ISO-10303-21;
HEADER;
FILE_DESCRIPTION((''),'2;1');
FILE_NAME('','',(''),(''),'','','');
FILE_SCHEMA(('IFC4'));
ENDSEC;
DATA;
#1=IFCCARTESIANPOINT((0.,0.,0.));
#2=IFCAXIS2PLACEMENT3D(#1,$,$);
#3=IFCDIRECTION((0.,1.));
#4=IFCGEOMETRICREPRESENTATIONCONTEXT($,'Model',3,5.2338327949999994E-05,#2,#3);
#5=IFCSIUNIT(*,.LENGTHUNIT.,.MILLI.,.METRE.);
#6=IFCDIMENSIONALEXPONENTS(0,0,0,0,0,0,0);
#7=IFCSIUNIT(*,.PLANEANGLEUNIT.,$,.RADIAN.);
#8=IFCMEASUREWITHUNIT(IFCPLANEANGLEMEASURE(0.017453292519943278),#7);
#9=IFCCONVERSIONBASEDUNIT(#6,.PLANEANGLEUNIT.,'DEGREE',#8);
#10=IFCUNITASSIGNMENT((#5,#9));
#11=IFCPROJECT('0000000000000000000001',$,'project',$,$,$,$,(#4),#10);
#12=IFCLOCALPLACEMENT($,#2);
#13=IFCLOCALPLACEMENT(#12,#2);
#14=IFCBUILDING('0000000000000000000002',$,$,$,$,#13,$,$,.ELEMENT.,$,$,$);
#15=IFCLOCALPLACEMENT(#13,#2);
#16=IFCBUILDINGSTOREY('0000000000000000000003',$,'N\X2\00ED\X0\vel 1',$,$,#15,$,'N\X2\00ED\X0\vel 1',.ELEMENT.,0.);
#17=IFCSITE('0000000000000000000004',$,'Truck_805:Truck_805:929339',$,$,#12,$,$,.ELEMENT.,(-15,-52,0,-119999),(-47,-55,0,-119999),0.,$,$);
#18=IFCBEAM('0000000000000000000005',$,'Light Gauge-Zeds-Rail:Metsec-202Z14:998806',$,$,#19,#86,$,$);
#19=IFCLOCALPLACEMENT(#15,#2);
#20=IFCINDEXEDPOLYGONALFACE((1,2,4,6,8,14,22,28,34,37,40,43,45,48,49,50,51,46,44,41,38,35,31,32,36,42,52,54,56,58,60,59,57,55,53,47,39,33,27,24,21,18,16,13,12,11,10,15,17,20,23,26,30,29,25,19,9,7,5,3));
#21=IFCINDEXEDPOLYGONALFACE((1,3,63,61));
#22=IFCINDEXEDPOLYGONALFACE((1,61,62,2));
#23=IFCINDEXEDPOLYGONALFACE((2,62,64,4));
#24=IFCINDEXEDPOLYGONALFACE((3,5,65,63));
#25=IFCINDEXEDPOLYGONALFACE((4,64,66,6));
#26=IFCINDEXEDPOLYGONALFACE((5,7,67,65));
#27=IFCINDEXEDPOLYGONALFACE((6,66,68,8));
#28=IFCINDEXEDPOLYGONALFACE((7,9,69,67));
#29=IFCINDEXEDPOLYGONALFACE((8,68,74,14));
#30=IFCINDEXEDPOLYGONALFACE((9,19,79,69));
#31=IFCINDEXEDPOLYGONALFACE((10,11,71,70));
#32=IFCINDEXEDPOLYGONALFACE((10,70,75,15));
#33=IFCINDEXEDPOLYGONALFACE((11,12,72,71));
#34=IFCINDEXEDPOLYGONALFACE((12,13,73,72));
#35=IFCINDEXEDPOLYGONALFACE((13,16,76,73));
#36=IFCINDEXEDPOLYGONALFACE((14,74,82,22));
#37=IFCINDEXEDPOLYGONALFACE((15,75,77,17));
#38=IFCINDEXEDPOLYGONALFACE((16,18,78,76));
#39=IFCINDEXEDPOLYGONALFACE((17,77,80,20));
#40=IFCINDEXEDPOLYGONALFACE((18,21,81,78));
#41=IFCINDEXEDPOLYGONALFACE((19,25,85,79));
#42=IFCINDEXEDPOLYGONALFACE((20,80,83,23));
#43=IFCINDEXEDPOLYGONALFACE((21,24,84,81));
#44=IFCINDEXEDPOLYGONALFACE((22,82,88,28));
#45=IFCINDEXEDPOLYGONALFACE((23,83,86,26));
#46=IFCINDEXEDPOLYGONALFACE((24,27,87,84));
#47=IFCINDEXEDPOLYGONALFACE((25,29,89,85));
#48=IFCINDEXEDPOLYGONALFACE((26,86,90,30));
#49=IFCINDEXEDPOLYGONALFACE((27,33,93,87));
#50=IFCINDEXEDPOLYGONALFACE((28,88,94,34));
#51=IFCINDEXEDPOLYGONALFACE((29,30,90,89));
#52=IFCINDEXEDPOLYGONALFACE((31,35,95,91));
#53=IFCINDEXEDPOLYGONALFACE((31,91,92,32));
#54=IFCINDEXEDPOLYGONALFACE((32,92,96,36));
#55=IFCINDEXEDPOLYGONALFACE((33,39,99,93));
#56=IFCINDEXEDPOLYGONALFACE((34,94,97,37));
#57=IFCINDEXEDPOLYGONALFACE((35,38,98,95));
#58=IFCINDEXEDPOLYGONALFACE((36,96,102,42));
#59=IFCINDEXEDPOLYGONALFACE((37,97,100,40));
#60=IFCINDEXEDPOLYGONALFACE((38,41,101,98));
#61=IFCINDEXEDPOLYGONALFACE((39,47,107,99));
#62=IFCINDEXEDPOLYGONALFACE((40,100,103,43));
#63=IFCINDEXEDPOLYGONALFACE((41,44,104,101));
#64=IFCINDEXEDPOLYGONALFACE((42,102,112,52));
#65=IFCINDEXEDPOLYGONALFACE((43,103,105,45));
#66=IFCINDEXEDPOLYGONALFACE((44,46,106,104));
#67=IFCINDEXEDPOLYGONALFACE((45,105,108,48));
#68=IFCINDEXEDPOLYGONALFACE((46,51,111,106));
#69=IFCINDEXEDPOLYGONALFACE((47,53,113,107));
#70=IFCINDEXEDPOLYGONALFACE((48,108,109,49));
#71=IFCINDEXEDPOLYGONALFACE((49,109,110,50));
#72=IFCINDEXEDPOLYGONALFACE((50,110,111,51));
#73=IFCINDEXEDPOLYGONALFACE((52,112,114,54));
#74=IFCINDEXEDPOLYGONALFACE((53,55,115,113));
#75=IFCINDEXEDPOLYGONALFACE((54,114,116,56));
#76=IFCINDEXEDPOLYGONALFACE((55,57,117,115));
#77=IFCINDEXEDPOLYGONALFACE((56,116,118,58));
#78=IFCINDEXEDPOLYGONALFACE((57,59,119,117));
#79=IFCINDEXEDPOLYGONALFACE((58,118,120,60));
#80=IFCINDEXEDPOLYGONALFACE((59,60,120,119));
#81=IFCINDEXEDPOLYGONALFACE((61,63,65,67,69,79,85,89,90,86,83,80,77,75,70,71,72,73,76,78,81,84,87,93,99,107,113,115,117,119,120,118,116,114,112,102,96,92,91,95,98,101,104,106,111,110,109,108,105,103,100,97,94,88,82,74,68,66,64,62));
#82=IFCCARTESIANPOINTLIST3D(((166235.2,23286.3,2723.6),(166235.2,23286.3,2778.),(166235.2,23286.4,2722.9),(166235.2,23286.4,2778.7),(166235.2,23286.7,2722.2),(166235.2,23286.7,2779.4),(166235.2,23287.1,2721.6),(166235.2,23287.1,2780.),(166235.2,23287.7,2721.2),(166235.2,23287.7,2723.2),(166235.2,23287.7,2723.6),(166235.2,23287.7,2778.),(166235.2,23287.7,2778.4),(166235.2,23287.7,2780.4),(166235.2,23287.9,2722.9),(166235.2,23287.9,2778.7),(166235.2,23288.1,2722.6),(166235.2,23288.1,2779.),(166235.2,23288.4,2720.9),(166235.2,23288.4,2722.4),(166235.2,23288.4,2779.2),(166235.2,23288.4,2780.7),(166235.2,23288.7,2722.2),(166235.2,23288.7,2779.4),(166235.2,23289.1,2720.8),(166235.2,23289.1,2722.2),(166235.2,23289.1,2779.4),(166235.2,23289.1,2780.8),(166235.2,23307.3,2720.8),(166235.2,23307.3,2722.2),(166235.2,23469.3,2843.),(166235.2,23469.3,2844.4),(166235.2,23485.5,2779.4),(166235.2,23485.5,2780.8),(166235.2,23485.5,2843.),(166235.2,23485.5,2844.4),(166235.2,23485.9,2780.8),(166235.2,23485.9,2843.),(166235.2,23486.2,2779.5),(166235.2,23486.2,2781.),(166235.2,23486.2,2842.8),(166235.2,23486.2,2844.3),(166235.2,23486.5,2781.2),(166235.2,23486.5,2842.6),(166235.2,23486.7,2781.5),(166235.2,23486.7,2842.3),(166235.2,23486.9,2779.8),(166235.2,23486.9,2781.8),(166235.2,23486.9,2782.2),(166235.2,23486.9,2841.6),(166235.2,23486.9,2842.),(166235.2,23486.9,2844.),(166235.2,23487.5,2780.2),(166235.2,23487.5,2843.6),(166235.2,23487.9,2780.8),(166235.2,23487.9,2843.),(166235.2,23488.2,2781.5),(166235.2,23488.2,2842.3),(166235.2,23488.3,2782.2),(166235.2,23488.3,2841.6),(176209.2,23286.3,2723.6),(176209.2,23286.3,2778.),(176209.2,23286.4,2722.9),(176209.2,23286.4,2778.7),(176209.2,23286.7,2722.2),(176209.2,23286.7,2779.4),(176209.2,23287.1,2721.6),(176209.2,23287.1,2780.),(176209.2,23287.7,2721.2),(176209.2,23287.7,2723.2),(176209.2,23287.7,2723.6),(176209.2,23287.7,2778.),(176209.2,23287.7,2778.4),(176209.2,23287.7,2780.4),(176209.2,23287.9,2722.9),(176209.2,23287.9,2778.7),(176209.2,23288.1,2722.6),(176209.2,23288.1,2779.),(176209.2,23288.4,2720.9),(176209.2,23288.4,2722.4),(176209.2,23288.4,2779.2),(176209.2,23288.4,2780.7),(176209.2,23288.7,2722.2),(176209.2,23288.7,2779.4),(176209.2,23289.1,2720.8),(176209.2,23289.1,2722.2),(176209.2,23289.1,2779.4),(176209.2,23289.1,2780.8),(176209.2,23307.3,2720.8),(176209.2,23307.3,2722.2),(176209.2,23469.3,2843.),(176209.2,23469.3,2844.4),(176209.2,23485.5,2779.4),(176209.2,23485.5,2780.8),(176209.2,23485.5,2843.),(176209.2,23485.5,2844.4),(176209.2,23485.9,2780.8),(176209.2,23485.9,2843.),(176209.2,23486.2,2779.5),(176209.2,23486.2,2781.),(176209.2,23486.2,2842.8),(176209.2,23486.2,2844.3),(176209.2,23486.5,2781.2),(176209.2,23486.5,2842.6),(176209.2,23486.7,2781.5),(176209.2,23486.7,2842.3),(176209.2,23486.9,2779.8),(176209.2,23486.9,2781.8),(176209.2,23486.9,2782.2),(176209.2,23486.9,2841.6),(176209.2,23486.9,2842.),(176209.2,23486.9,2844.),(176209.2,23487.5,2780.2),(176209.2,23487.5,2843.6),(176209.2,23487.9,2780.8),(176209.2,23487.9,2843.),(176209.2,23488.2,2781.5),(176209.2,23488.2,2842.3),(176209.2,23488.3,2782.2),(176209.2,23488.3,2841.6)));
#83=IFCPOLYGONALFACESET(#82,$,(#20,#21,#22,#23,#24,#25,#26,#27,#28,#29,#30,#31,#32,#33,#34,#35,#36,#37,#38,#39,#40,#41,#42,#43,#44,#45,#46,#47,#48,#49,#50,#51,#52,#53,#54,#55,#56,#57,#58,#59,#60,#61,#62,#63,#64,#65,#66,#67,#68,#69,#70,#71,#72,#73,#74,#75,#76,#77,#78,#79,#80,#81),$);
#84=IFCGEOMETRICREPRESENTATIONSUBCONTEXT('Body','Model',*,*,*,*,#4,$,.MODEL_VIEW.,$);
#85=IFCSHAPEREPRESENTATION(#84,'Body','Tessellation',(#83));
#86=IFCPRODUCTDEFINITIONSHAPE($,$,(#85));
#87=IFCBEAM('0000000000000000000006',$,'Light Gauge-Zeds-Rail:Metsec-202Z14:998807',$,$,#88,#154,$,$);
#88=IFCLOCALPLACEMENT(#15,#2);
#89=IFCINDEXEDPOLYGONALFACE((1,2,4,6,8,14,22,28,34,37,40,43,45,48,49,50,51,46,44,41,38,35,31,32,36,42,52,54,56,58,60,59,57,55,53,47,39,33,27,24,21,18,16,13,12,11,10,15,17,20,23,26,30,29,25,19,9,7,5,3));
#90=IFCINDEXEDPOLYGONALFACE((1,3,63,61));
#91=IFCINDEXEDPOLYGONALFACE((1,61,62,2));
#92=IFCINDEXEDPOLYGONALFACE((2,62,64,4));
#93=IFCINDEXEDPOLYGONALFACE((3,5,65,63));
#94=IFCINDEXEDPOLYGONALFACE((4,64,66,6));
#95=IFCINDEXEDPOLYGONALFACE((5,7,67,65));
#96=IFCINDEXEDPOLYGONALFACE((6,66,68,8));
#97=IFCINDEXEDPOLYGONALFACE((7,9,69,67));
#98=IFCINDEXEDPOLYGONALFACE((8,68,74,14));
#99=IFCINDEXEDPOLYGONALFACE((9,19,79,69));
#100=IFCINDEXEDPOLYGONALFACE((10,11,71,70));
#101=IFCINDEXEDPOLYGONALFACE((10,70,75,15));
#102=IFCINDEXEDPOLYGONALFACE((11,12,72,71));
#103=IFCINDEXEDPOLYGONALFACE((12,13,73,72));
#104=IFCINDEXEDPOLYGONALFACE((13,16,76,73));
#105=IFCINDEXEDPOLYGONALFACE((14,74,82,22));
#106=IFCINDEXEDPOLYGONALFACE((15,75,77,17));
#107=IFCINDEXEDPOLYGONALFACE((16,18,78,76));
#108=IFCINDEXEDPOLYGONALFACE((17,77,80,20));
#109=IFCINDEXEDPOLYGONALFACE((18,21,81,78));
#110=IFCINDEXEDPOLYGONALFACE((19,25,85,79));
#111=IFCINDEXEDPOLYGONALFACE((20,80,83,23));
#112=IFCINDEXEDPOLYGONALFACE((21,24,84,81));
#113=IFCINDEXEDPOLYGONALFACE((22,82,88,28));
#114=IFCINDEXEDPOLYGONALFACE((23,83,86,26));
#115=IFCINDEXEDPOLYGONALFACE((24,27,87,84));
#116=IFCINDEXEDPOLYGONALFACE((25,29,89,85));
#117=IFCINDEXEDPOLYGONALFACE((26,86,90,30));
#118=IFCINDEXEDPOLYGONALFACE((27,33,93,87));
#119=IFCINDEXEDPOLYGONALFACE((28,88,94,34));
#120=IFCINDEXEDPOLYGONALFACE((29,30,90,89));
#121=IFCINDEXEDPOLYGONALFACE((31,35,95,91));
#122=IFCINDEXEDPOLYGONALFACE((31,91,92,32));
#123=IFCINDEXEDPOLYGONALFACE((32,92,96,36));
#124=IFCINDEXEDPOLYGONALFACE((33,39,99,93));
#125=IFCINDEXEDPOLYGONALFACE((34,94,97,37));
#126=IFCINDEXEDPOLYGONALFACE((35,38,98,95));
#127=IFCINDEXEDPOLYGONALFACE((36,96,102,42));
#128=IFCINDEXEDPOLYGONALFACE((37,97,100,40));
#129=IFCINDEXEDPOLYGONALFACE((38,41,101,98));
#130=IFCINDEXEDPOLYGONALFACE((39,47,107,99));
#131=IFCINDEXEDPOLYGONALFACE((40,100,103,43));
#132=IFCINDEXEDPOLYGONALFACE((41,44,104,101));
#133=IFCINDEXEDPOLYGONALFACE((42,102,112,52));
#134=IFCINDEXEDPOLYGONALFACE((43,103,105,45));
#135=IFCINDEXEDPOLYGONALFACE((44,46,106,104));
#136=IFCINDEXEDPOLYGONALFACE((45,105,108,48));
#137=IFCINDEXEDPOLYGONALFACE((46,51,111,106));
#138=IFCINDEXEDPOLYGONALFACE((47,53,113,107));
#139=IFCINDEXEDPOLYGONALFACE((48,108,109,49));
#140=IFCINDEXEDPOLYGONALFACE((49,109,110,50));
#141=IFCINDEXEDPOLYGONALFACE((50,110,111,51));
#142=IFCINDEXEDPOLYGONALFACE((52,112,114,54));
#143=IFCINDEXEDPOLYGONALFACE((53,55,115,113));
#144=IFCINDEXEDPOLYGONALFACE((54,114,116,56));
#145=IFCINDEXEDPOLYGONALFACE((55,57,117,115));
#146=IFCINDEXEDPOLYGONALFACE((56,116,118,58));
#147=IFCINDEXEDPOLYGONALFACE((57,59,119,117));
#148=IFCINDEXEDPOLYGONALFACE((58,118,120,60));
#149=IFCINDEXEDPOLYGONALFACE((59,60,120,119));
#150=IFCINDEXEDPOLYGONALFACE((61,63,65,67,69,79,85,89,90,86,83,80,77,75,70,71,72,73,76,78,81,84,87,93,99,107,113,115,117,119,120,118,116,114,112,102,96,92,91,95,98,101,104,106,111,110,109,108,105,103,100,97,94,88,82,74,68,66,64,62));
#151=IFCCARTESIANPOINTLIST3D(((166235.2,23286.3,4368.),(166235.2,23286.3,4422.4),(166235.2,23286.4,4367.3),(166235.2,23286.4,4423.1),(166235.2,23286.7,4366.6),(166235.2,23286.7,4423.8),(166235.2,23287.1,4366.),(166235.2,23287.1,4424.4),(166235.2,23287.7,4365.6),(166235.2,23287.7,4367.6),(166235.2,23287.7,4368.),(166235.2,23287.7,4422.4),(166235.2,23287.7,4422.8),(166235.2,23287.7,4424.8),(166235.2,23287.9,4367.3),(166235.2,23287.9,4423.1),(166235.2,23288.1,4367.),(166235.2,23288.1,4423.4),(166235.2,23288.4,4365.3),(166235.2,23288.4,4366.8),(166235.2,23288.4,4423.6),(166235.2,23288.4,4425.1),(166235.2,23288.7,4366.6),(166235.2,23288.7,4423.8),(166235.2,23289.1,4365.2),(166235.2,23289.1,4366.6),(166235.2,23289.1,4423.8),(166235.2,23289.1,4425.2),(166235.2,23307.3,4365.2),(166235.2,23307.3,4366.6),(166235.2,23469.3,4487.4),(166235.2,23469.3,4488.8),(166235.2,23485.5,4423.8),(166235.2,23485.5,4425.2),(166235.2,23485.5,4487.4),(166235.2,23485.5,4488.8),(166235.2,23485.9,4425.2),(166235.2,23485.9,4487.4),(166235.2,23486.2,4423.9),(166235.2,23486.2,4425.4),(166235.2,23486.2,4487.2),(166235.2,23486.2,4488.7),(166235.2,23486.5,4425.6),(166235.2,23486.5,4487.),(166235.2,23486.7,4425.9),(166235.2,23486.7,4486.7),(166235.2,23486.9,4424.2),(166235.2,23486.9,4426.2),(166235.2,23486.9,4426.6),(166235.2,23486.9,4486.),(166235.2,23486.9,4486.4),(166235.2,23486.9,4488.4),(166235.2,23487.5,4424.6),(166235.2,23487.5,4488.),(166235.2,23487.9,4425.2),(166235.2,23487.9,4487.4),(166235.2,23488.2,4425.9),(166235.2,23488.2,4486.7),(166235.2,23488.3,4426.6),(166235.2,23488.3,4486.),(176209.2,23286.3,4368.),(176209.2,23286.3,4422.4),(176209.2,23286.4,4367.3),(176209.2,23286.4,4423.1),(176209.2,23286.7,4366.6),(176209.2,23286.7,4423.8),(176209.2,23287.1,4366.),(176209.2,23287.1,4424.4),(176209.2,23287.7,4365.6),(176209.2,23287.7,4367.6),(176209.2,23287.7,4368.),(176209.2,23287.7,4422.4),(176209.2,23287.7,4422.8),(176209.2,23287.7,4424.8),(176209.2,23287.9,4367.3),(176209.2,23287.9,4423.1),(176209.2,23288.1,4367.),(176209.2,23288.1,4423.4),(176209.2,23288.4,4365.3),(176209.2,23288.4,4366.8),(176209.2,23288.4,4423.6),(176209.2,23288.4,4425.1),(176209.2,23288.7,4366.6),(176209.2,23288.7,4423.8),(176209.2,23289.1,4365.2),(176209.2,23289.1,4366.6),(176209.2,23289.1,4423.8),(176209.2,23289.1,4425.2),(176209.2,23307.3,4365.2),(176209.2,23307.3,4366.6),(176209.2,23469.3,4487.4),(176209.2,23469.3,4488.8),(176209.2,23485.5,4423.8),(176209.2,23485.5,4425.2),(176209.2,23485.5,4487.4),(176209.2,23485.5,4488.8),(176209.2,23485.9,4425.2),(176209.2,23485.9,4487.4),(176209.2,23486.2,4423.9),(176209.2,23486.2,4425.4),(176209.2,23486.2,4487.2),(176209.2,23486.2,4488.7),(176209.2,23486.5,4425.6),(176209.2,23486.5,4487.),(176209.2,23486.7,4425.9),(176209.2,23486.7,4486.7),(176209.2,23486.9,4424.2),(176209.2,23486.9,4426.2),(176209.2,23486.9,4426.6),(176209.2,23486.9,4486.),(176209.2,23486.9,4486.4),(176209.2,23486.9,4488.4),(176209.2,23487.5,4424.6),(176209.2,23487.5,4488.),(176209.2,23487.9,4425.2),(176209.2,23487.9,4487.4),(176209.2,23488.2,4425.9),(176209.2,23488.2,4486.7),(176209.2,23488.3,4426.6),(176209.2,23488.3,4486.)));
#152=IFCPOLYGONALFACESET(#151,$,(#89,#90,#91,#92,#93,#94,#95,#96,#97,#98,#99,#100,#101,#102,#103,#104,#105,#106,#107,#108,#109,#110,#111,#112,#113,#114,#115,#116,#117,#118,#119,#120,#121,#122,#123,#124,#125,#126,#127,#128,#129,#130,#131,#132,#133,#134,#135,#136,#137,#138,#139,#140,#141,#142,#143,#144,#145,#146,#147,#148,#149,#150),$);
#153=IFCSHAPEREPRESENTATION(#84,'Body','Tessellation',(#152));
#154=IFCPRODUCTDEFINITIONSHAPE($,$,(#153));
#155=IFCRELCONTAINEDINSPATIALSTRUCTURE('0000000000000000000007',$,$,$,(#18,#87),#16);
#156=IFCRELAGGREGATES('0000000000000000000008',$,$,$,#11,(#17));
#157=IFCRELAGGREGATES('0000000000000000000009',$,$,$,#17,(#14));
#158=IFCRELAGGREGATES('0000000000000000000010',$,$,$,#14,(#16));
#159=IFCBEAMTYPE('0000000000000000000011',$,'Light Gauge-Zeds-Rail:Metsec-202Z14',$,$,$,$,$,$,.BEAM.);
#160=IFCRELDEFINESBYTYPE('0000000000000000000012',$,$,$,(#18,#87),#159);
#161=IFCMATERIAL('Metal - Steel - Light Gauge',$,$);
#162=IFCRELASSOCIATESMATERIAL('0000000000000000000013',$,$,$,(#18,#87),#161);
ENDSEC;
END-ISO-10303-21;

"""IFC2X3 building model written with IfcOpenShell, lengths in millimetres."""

from ifc_helpers import new_model, entity, si_unit, converted_unit, direction, frame, frame_2d, origin, place, context, subcontext, project, spatial, polyline, circle_curve, parameter, trimmed, segment, composite_curve, outline, extrude, material, type_object, element, save


model = new_model("IFC2X3")

# Units and contexts
model_context = context("Model", 3, precision=5.2338327949999994e-05, world=origin(), true_north=direction((0.0, 1.0)))
body_context = subcontext(model_context, "Body", "Model", "MODEL_VIEW")
ifc_project = project(units=[si_unit("LENGTHUNIT", "METRE", prefix="MILLI"), converted_unit("PLANEANGLEUNIT", "DEGREE", entity("IfcPlaneAngleMeasure", 0.017453292519943278), si_unit("PLANEANGLEUNIT", "RADIAN"), dimensions=[0, 0, 0, 0, 0, 0, 0])], contexts=[model_context])

# Site, building, storey
site_placement = place(None, origin())
site = spatial("IfcSite", under=ifc_project, at=site_placement, Name="Truck_805:Truck_805:929339", CompositionType="ELEMENT", RefLatitude=(-15, -52, 0, -119999), RefLongitude=(-47, -55, 0, -119999), RefElevation=0.0)
building_placement = place(site_placement, origin())
building = spatial("IfcBuilding", under=site, at=building_placement, CompositionType="ELEMENT")
storey_placement = place(building_placement, origin())
storey = spatial("IfcBuildingStorey", under=building, at=storey_placement, Name="Nível 1", LongName="Nível 1", CompositionType="ELEMENT", Elevation=0.0)

# Beams
ifc_material_1 = material(Name="Metal - Steel - Light Gauge")
beam_type_1 = type_object("IfcBeamType", Name="Light Gauge-Zeds-Rail:Metsec-202Z14", PredefinedType="BEAM")
beam_1_placement = place(storey_placement, frame((166222.2, 23388.2, 2844.4)))
element("IfcBeam", 1, at=beam_1_placement, inside=storey, type_object=beam_type_1, material=ifc_material_1, Name="Light Gauge-Zeds-Rail:Metsec-202Z14:998806", context=body_context, shape_type="SweptSolid", body=[
    extrude(outline(composite_curve([segment(polyline([(3.6, -101.2), (58.0, -101.2)]), True, "CONTINUOUS"), segment(trimmed(circle_curve(frame_2d((58.0, -98.4), x_axis=(0.0, -1.0)), 2.8), [parameter(0.0)], [parameter(90.0)], True, "PARAMETER"), True, "CONTINUOUS"), segment(polyline([(60.8, -98.4), (60.8, -80.2)]), True, "CONTINUOUS"), segment(polyline([(60.8, -80.2), (59.4, -80.2)]), True, "CONTINUOUS"), segment(polyline([(59.4, -80.2), (59.4, -98.4)]), True, "CONTINUOUS"), segment(trimmed(circle_curve(frame_2d((58.0, -98.4), x_axis=(1.0, 0.0)), 1.4), [parameter(270.0)], [parameter(0.0)], True, "PARAMETER"), False, "CONTINUOUS"), segment(polyline([(58.0, -99.8), (3.6, -99.8)]), True, "CONTINUOUS"), segment(trimmed(circle_curve(frame_2d((3.6, -98.4), x_axis=(0.0, -1.0)), 1.4), [parameter(270.0)], [parameter(0.0)], True, "PARAMETER"), False, "CONTINUOUS"), segment(polyline([(2.2, -98.4), (2.2, 98.0)]), True, "CONTINUOUS"), segment(trimmed(circle_curve(frame_2d((-0.6, 98.0), x_axis=(1.0, 0.0)), 2.8), [parameter(0.0)], [parameter(90.0)], True, "PARAMETER"), True, "CONTINUOUS"), segment(polyline([(-0.6, 100.8), (-60.0, 100.8)]), True, "CONTINUOUS"), segment(trimmed(circle_curve(frame_2d((-60.0, 98.0), x_axis=(0.0, 1.0)), 2.8), [parameter(0.0)], [parameter(90.0)], True, "PARAMETER"), True, "CONTINUOUS"), segment(polyline([(-62.8, 98.0), (-62.8, 81.8)]), True, "CONTINUOUS"), segment(polyline([(-62.8, 81.8), (-61.4, 81.8)]), True, "CONTINUOUS"), segment(polyline([(-61.4, 81.8), (-61.4, 98.0)]), True, "CONTINUOUS"), segment(trimmed(circle_curve(frame_2d((-60.0, 98.0), x_axis=(-1.0, 0.0)), 1.4), [parameter(270.0)], [parameter(0.0)], True, "PARAMETER"), False, "CONTINUOUS"), segment(polyline([(-60.0, 99.4), (-0.6, 99.4)]), True, "CONTINUOUS"), segment(trimmed(circle_curve(frame_2d((-0.6, 98.0), x_axis=(0.0, 1.0)), 1.4), [parameter(270.0)], [parameter(0.0)], True, "PARAMETER"), False, "CONTINUOUS"), segment(polyline([(0.8, 98.0), (0.8, -98.4)]), True, "CONTINUOUS"), segment(trimmed(circle_curve(frame_2d((3.6, -98.4), x_axis=(-1.0, 0.0)), 2.8), [parameter(0.0)], [parameter(90.0)], True, "PARAMETER"), True, "CONTINUOUS")], self_intersect=False)), frame((13.0, -0.7, -62.8), z_axis=(1.0, 0.0, 0.0), x_axis=(0.0, 0.0, -1.0)), (0.0, 0.0, 1.0), 9974.0),
])
beam_2_placement = place(storey_placement, frame((166222.2, 23388.2, 4488.8)))
element("IfcBeam", 2, at=beam_2_placement, inside=storey, type_object=beam_type_1, material=ifc_material_1, Name="Light Gauge-Zeds-Rail:Metsec-202Z14:998807", context=body_context, shape_type="SweptSolid", body=[
    extrude(outline(composite_curve([segment(polyline([(3.6, -101.2), (58.0, -101.2)]), True, "CONTINUOUS"), segment(trimmed(circle_curve(frame_2d((58.0, -98.4), x_axis=(0.0, -1.0)), 2.8), [parameter(0.0)], [parameter(90.0)], True, "PARAMETER"), True, "CONTINUOUS"), segment(polyline([(60.8, -98.4), (60.8, -80.2)]), True, "CONTINUOUS"), segment(polyline([(60.8, -80.2), (59.4, -80.2)]), True, "CONTINUOUS"), segment(polyline([(59.4, -80.2), (59.4, -98.4)]), True, "CONTINUOUS"), segment(trimmed(circle_curve(frame_2d((58.0, -98.4), x_axis=(1.0, 0.0)), 1.4), [parameter(270.0)], [parameter(0.0)], True, "PARAMETER"), False, "CONTINUOUS"), segment(polyline([(58.0, -99.8), (3.6, -99.8)]), True, "CONTINUOUS"), segment(trimmed(circle_curve(frame_2d((3.6, -98.4), x_axis=(0.0, -1.0)), 1.4), [parameter(270.0)], [parameter(0.0)], True, "PARAMETER"), False, "CONTINUOUS"), segment(polyline([(2.2, -98.4), (2.2, 98.0)]), True, "CONTINUOUS"), segment(trimmed(circle_curve(frame_2d((-0.6, 98.0), x_axis=(1.0, 0.0)), 2.8), [parameter(0.0)], [parameter(90.0)], True, "PARAMETER"), True, "CONTINUOUS"), segment(polyline([(-0.6, 100.8), (-60.0, 100.8)]), True, "CONTINUOUS"), segment(trimmed(circle_curve(frame_2d((-60.0, 98.0), x_axis=(0.0, 1.0)), 2.8), [parameter(0.0)], [parameter(90.0)], True, "PARAMETER"), True, "CONTINUOUS"), segment(polyline([(-62.8, 98.0), (-62.8, 81.8)]), True, "CONTINUOUS"), segment(polyline([(-62.8, 81.8), (-61.4, 81.8)]), True, "CONTINUOUS"), segment(polyline([(-61.4, 81.8), (-61.4, 98.0)]), True, "CONTINUOUS"), segment(trimmed(circle_curve(frame_2d((-60.0, 98.0), x_axis=(-1.0, 0.0)), 1.4), [parameter(270.0)], [parameter(0.0)], True, "PARAMETER"), False, "CONTINUOUS"), segment(polyline([(-60.0, 99.4), (-0.6, 99.4)]), True, "CONTINUOUS"), segment(trimmed(circle_curve(frame_2d((-0.6, 98.0), x_axis=(0.0, 1.0)), 1.4), [parameter(270.0)], [parameter(0.0)], True, "PARAMETER"), False, "CONTINUOUS"), segment(polyline([(0.8, 98.0), (0.8, -98.4)]), True, "CONTINUOUS"), segment(trimmed(circle_curve(frame_2d((3.6, -98.4), x_axis=(-1.0, 0.0)), 2.8), [parameter(0.0)], [parameter(90.0)], True, "PARAMETER"), True, "CONTINUOUS")], self_intersect=False)), frame((13.0, -0.7, -62.8), z_axis=(1.0, 0.0, 0.0), x_axis=(0.0, 0.0, -1.0)), (0.0, 0.0, 1.0), 9974.0),
])

save(model, "model.ifc")
